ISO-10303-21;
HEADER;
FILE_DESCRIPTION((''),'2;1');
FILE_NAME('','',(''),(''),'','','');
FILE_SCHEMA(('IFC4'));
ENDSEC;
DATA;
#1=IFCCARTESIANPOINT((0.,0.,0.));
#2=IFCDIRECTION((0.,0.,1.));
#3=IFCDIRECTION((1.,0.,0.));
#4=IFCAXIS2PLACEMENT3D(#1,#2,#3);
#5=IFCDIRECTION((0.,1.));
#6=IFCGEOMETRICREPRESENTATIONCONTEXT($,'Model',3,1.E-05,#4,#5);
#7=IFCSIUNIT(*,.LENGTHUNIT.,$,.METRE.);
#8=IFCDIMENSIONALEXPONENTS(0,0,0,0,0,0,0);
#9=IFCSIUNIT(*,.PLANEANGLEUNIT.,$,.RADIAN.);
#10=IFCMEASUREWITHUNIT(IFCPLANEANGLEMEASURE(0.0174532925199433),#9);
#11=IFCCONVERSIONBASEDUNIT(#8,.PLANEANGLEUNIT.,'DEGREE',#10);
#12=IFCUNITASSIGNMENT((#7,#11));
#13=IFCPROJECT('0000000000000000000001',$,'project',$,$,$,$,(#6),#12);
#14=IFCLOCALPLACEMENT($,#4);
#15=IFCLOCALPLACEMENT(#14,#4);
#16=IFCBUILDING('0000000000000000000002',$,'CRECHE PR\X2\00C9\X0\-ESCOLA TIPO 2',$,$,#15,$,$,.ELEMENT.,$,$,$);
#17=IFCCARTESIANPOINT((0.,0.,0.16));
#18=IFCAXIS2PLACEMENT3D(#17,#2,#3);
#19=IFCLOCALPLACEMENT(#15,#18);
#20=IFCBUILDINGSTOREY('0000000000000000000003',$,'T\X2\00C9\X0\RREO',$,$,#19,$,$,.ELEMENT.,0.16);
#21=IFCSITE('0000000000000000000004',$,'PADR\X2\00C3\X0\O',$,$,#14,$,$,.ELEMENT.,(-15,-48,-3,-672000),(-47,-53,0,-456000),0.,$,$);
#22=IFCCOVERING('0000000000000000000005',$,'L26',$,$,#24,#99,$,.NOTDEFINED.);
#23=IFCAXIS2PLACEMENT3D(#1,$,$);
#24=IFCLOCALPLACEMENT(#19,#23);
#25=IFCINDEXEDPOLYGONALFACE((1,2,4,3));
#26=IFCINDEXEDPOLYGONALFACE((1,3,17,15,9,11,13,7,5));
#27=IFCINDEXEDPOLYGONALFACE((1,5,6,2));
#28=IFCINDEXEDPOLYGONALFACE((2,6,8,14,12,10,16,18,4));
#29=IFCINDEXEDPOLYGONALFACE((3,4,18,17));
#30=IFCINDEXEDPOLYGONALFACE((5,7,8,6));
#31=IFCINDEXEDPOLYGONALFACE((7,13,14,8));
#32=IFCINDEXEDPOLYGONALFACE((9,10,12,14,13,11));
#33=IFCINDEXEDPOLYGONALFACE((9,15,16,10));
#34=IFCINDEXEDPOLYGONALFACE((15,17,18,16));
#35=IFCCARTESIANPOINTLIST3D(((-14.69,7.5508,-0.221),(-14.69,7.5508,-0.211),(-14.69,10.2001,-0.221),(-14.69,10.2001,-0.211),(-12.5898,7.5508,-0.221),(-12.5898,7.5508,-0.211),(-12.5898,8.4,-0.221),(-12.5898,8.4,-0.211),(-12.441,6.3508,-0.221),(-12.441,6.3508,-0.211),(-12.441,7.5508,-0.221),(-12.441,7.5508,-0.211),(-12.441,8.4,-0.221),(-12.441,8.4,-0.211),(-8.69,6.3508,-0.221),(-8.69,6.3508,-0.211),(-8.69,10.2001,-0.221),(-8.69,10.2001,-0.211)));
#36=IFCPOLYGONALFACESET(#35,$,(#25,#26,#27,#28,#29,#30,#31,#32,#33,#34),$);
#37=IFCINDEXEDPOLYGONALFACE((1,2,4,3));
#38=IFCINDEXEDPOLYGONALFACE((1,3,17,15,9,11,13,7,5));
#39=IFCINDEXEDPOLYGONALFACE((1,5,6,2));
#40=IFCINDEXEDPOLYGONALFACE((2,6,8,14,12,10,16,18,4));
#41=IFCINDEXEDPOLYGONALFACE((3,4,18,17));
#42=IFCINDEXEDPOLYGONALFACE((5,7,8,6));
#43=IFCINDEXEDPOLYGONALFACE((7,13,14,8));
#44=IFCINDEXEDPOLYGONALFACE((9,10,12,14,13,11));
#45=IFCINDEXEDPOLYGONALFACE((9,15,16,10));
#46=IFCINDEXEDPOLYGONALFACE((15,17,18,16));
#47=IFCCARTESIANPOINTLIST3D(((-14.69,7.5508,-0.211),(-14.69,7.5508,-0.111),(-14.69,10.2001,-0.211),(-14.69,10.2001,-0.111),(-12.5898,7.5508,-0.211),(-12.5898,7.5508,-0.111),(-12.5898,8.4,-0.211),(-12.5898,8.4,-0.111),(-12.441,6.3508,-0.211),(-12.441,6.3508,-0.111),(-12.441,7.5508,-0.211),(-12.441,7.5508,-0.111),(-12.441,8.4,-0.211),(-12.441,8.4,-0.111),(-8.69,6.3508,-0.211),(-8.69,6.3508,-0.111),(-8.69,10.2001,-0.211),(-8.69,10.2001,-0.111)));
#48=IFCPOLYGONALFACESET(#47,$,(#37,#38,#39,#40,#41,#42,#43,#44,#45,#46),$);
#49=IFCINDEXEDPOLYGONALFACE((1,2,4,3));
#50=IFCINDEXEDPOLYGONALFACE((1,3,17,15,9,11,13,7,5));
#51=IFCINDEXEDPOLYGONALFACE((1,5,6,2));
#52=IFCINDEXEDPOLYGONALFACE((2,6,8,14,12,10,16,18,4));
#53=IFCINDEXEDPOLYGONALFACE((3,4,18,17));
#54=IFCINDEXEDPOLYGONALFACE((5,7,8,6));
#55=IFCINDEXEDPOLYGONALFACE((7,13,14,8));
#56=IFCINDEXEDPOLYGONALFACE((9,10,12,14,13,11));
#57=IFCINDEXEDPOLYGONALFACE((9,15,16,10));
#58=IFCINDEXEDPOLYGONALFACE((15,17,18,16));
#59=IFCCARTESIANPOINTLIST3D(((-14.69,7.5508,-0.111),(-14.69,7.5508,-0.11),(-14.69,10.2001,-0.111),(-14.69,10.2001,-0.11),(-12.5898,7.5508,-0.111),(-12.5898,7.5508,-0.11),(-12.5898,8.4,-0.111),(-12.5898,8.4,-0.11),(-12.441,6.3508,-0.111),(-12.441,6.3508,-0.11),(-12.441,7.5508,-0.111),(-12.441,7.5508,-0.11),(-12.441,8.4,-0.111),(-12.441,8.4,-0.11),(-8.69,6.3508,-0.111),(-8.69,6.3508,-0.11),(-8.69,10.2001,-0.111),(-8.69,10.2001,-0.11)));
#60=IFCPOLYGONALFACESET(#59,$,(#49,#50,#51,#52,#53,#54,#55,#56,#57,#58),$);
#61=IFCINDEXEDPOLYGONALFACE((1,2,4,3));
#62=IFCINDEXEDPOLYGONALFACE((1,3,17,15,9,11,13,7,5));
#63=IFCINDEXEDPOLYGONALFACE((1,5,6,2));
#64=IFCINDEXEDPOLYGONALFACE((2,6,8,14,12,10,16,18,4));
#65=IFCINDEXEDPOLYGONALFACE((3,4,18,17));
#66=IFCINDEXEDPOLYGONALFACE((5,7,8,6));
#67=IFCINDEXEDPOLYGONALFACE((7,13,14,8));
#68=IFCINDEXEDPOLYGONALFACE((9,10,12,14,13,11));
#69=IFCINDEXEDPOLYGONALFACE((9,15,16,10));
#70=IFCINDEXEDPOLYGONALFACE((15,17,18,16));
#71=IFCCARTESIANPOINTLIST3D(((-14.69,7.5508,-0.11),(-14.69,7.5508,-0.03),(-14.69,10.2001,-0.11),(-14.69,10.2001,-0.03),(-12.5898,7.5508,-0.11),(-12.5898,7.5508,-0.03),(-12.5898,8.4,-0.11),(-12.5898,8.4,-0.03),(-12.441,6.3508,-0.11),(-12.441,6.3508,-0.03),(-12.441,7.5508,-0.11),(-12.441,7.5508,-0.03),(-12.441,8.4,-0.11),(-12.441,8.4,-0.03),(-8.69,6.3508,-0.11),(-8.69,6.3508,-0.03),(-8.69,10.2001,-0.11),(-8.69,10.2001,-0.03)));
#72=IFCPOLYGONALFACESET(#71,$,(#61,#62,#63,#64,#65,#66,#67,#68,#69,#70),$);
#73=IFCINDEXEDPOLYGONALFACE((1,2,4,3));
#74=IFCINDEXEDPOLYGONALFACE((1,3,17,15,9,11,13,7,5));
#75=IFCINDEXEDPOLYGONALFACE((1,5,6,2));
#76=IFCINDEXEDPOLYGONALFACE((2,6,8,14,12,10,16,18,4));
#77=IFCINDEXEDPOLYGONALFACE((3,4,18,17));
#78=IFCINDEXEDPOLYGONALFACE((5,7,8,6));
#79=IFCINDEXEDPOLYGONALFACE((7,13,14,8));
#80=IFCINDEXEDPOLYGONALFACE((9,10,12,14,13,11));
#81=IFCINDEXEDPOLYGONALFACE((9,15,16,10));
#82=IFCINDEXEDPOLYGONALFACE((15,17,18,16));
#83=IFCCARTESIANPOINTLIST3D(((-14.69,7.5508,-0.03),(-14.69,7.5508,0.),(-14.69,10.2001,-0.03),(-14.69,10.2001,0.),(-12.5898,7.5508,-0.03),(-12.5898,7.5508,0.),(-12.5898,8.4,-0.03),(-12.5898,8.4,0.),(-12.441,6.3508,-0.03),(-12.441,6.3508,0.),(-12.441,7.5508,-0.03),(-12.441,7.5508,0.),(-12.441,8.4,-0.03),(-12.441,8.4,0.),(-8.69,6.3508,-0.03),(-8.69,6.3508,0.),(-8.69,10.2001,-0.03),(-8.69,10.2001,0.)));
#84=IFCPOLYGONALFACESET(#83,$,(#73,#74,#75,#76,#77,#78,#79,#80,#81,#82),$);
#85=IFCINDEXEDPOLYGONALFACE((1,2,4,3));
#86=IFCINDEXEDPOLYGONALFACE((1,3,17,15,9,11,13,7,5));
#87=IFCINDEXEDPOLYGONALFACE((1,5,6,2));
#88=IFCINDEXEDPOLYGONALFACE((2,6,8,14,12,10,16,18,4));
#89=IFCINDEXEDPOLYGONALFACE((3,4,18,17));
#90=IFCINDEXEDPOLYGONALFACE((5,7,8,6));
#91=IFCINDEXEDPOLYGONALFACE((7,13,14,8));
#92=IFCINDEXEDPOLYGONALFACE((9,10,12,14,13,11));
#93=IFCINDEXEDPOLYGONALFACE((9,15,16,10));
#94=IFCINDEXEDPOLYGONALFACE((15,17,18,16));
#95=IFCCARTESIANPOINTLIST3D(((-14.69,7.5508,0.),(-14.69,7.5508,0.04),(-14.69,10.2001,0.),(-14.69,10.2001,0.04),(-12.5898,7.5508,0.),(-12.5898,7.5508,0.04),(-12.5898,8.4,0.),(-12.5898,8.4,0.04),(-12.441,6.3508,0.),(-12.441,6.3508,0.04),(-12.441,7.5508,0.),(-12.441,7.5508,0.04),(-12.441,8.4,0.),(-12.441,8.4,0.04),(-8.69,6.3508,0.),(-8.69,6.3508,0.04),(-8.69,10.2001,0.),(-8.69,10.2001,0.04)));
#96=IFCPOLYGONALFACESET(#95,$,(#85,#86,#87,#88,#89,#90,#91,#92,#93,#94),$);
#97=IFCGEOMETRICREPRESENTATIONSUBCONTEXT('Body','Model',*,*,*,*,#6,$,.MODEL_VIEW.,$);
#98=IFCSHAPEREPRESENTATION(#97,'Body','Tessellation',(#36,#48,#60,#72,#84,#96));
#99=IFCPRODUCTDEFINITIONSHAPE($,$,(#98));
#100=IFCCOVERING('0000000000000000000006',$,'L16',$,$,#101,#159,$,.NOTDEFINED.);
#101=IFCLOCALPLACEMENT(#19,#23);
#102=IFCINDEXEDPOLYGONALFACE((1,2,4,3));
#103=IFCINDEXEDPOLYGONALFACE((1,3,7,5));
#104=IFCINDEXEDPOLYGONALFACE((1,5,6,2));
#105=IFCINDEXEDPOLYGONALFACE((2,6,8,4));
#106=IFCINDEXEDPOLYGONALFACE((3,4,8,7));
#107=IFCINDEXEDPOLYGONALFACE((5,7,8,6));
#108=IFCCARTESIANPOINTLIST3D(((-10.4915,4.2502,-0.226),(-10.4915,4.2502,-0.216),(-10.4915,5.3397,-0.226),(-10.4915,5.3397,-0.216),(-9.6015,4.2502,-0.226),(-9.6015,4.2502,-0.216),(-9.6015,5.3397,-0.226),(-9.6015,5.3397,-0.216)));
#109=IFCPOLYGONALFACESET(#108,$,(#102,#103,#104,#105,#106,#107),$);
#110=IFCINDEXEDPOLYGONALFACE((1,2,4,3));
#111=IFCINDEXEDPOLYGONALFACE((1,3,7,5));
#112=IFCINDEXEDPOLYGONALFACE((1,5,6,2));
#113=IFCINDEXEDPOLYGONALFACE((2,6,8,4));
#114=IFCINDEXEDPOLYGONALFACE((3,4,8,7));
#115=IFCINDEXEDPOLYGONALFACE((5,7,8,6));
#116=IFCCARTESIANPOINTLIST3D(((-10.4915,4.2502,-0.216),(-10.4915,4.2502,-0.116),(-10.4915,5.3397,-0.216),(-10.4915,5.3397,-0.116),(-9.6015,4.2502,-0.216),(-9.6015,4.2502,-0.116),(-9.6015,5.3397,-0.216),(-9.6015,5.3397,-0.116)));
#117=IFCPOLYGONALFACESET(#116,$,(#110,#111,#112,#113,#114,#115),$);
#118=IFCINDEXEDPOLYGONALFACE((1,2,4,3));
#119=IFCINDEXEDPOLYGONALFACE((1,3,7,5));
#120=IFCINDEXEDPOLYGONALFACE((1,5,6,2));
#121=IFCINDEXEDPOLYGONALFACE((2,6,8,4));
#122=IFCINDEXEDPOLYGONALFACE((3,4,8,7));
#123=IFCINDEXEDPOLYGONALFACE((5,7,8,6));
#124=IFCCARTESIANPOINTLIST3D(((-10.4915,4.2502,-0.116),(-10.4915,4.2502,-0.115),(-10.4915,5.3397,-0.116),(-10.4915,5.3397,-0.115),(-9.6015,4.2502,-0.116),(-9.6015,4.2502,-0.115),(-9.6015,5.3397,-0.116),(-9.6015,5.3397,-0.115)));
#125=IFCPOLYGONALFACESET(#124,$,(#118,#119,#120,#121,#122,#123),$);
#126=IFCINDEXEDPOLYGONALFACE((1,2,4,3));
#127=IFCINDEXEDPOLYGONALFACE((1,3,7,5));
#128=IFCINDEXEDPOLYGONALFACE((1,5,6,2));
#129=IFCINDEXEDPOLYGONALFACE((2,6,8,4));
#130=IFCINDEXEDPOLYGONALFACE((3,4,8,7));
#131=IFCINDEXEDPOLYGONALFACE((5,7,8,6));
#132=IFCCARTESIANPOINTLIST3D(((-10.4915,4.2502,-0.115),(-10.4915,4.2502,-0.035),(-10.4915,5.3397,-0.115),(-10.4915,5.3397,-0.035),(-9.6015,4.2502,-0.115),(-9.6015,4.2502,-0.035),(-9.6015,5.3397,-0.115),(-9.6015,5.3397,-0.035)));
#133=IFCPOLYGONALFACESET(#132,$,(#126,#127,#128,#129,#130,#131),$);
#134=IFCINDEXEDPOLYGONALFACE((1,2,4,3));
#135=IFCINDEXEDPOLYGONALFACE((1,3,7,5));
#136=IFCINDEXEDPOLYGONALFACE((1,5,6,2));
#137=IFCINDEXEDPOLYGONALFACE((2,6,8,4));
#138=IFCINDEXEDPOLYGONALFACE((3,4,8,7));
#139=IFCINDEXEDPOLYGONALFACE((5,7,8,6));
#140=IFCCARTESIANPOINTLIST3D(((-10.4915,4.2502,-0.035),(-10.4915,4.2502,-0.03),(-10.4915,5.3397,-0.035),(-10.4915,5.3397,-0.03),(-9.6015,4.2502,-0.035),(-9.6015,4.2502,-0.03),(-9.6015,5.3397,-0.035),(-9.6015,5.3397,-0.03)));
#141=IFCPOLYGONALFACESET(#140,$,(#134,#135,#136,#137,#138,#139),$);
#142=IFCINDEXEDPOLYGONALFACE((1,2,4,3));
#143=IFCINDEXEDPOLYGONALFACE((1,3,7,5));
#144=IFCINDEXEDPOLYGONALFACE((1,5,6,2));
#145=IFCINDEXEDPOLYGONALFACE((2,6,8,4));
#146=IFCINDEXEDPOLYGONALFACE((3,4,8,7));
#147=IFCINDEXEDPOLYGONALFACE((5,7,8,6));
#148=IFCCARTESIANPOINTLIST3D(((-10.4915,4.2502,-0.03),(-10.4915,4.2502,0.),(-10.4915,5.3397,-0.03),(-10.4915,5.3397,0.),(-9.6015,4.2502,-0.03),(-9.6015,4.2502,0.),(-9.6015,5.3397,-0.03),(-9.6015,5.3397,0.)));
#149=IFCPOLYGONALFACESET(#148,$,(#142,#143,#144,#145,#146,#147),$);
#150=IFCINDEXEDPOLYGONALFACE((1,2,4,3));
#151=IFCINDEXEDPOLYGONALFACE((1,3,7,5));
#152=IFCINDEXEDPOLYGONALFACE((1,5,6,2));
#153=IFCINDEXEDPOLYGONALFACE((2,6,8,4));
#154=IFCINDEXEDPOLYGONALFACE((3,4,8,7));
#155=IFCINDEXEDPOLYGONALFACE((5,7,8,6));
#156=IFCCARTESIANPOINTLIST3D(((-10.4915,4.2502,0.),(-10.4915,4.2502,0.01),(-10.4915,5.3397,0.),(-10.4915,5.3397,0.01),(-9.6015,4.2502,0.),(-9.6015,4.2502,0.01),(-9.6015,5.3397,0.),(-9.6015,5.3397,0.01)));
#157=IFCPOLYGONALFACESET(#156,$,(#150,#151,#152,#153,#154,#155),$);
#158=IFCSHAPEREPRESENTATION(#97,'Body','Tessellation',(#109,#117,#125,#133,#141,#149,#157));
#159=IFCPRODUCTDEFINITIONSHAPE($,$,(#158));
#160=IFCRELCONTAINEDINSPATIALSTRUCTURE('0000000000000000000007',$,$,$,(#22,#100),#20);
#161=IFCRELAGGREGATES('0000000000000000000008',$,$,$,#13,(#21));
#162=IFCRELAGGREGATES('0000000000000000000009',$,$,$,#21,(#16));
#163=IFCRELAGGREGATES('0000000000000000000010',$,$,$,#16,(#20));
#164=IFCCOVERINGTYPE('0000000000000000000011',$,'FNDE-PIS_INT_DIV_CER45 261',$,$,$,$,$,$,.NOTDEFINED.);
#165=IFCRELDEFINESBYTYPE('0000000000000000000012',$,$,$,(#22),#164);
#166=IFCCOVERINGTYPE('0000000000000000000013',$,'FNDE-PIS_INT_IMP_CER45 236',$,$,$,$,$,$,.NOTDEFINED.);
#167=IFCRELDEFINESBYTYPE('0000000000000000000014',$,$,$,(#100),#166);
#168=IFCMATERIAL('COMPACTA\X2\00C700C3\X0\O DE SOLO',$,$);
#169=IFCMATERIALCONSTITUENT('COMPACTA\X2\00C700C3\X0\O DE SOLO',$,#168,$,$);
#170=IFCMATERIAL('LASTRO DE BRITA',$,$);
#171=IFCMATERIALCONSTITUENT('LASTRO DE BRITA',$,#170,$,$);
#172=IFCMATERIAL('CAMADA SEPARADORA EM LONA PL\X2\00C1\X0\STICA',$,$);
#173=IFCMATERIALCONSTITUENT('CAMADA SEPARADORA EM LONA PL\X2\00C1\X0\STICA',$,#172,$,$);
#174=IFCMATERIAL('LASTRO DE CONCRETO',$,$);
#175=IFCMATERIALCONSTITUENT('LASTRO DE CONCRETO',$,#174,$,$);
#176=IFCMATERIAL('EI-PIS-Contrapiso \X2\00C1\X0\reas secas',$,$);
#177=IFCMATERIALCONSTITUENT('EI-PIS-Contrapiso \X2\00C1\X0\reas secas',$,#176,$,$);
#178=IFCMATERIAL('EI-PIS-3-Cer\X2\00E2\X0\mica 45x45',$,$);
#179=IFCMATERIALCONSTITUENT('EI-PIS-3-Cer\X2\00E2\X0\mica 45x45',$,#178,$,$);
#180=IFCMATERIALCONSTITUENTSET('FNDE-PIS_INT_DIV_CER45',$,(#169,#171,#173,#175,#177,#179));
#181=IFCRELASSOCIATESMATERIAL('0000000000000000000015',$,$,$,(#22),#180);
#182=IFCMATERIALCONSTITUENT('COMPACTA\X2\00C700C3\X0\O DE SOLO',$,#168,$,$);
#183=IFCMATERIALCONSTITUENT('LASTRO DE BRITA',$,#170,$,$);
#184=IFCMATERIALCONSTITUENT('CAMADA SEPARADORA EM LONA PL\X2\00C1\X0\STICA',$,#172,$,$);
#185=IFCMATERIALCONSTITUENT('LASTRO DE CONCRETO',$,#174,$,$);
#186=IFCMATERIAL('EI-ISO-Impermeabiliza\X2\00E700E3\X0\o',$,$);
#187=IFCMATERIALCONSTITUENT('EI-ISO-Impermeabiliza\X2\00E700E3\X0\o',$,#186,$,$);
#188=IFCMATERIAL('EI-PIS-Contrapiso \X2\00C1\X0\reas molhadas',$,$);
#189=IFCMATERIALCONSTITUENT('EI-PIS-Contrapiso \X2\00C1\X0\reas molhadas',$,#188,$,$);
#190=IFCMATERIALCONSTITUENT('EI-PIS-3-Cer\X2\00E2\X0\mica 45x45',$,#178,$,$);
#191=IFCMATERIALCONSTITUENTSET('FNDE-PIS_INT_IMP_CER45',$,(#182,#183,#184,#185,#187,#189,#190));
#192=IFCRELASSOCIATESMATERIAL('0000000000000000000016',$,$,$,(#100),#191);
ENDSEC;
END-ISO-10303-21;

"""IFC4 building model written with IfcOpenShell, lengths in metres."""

from ifc_helpers import new_model, entity, si_unit, converted_unit, direction, frame, origin_with_axes, place, context, subcontext, project, spatial, line, indexed_curve, outline, extrude, material, constituent, constituent_set, type_object, element, save


model = new_model("IFC4")

# Units and contexts
model_context = context("Model", 3, precision=1e-05, world=origin_with_axes(), true_north=direction((0.0, 1.0)))
body_context = subcontext(model_context, "Body", "Model", "MODEL_VIEW")
ifc_project = project(units=[si_unit("LENGTHUNIT", "METRE"), converted_unit("PLANEANGLEUNIT", "DEGREE", entity("IfcPlaneAngleMeasure", 0.0174532925199433), si_unit("PLANEANGLEUNIT", "RADIAN"), dimensions=[0, 0, 0, 0, 0, 0, 0])], contexts=[model_context])

# Site, building, storey
site_placement = place(None, origin_with_axes())
site = spatial("IfcSite", under=ifc_project, at=site_placement, Name="PADRÃO", CompositionType="ELEMENT", RefLatitude=(-15, -48, -3, -672000), RefLongitude=(-47, -53, 0, -456000), RefElevation=0.0)
building_placement = place(site_placement, origin_with_axes())
building = spatial("IfcBuilding", under=site, at=building_placement, Name="CRECHE PRÉ-ESCOLA TIPO 2", CompositionType="ELEMENT")
storey_placement = place(building_placement, frame((0.0, 0.0, 0.16), z_axis=(0.0, 0.0, 1.0), x_axis=(1.0, 0.0, 0.0)))
storey = spatial("IfcBuildingStorey", under=building, at=storey_placement, Name="TÉRREO", CompositionType="ELEMENT", Elevation=0.16)

# Coverings
ifc_material_1 = material(Name="COMPACTAÇÃO DE SOLO")
ifc_constituent_1 = constituent(ifc_material_1, Name="COMPACTAÇÃO DE SOLO")
ifc_material_2 = material(Name="LASTRO DE BRITA")
ifc_constituent_2 = constituent(ifc_material_2, Name="LASTRO DE BRITA")
ifc_material_3 = material(Name="CAMADA SEPARADORA EM LONA PLÁSTICA")
ifc_constituent_3 = constituent(ifc_material_3, Name="CAMADA SEPARADORA EM LONA PLÁSTICA")
ifc_material_4 = material(Name="LASTRO DE CONCRETO")
ifc_constituent_4 = constituent(ifc_material_4, Name="LASTRO DE CONCRETO")
ifc_material_5 = material(Name="EI-PIS-Contrapiso Áreas secas")
ifc_constituent_5 = constituent(ifc_material_5, Name="EI-PIS-Contrapiso Áreas secas")
ifc_material_6 = material(Name="EI-PIS-3-Cerâmica 45x45")
ifc_constituent_6 = constituent(ifc_material_6, Name="EI-PIS-3-Cerâmica 45x45")
ifc_constituent_set_1 = constituent_set(constituents=[ifc_constituent_1, ifc_constituent_2, ifc_constituent_3, ifc_constituent_4, ifc_constituent_5, ifc_constituent_6], Name="FNDE-PIS_INT_DIV_CER45")
covering_type_1 = type_object("IfcCoveringType", Name="FNDE-PIS_INT_DIV_CER45 261", PredefinedType="NOTDEFINED")
covering_1_placement = place(storey_placement, frame((-8.69, 10.2001, 0.04), z_axis=(0.0, 0.0, 1.0), x_axis=(1.0, 0.0, 0.0)))
element("IfcCovering", 1, at=covering_1_placement, inside=storey, type_object=covering_type_1, material=ifc_constituent_set_1, Name="L26", PredefinedType="NOTDEFINED", context=body_context, shape_type="SweptSolid", body=[
    extrude(outline(indexed_curve([(0.0, 0.0), (-6.0, 0.0), (-6.0, -2.6493), (-3.8998, -2.6493), (-3.8998, -1.8001), (-3.751, -1.8001), (-3.751, -2.6493), (-3.751, -3.8493), (0.0, -3.8493)], segments=[line(1, 2, 3, 4, 5, 6, 7, 8, 9, 1)])), frame((0.0, 0.0, -0.261), z_axis=(0.0, 0.0, 1.0), x_axis=(1.0, 0.0, 0.0)), (0.0, 0.0, 1.0), 0.01),
    extrude(outline(indexed_curve([(0.0, 0.0), (-6.0, 0.0), (-6.0, -2.6493), (-3.8998, -2.6493), (-3.8998, -1.8001), (-3.751, -1.8001), (-3.751, -2.6493), (-3.751, -3.8493), (0.0, -3.8493)], segments=[line(1, 2, 3, 4, 5, 6, 7, 8, 9, 1)])), frame((0.0, 0.0, -0.251), z_axis=(0.0, 0.0, 1.0), x_axis=(1.0, 0.0, 0.0)), (0.0, 0.0, 1.0), 0.1),
    extrude(outline(indexed_curve([(0.0, 0.0), (-6.0, 0.0), (-6.0, -2.6493), (-3.8998, -2.6493), (-3.8998, -1.8001), (-3.751, -1.8001), (-3.751, -2.6493), (-3.751, -3.8493), (0.0, -3.8493)], segments=[line(1, 2, 3, 4, 5, 6, 7, 8, 9, 1)])), frame((0.0, 0.0, -0.151), z_axis=(0.0, 0.0, 1.0), x_axis=(1.0, 0.0, 0.0)), (0.0, 0.0, 1.0), 0.001),
    extrude(outline(indexed_curve([(0.0, 0.0), (-6.0, 0.0), (-6.0, -2.6493), (-3.8998, -2.6493), (-3.8998, -1.8001), (-3.751, -1.8001), (-3.751, -2.6493), (-3.751, -3.8493), (0.0, -3.8493)], segments=[line(1, 2, 3, 4, 5, 6, 7, 8, 9, 1)])), frame((0.0, 0.0, -0.15), z_axis=(0.0, 0.0, 1.0), x_axis=(1.0, 0.0, 0.0)), (0.0, 0.0, 1.0), 0.08),
    extrude(outline(indexed_curve([(0.0, 0.0), (-6.0, 0.0), (-6.0, -2.6493), (-3.8998, -2.6493), (-3.8998, -1.8001), (-3.751, -1.8001), (-3.751, -2.6493), (-3.751, -3.8493), (0.0, -3.8493)], segments=[line(1, 2, 3, 4, 5, 6, 7, 8, 9, 1)])), frame((0.0, 0.0, -0.07), z_axis=(0.0, 0.0, 1.0), x_axis=(1.0, 0.0, 0.0)), (0.0, 0.0, 1.0), 0.03),
    extrude(outline(indexed_curve([(0.0, 0.0), (-6.0, 0.0), (-6.0, -2.6493), (-3.8998, -2.6493), (-3.8998, -1.8001), (-3.751, -1.8001), (-3.751, -2.6493), (-3.751, -3.8493), (0.0, -3.8493)], segments=[line(1, 2, 3, 4, 5, 6, 7, 8, 9, 1)])), frame((0.0, 0.0, -0.04), z_axis=(0.0, 0.0, 1.0), x_axis=(1.0, 0.0, 0.0)), (0.0, 0.0, 1.0), 0.04),
])
ifc_constituent_7 = constituent(ifc_material_1, Name="COMPACTAÇÃO DE SOLO")
ifc_constituent_8 = constituent(ifc_material_2, Name="LASTRO DE BRITA")
ifc_constituent_9 = constituent(ifc_material_3, Name="CAMADA SEPARADORA EM LONA PLÁSTICA")
ifc_constituent_10 = constituent(ifc_material_4, Name="LASTRO DE CONCRETO")
ifc_material_7 = material(Name="EI-ISO-Impermeabilização")
ifc_constituent_11 = constituent(ifc_material_7, Name="EI-ISO-Impermeabilização")
ifc_material_8 = material(Name="EI-PIS-Contrapiso Áreas molhadas")
ifc_constituent_12 = constituent(ifc_material_8, Name="EI-PIS-Contrapiso Áreas molhadas")
ifc_constituent_13 = constituent(ifc_material_6, Name="EI-PIS-3-Cerâmica 45x45")
ifc_constituent_set_2 = constituent_set(constituents=[ifc_constituent_7, ifc_constituent_8, ifc_constituent_9, ifc_constituent_10, ifc_constituent_11, ifc_constituent_12, ifc_constituent_13], Name="FNDE-PIS_INT_IMP_CER45")
covering_type_2 = type_object("IfcCoveringType", Name="FNDE-PIS_INT_IMP_CER45 236", PredefinedType="NOTDEFINED")
covering_2_placement = place(storey_placement, frame((-9.6015, 5.3397, 0.01), z_axis=(0.0, 0.0, 1.0), x_axis=(1.0, 0.0, 0.0)))
element("IfcCovering", 2, at=covering_2_placement, inside=storey, type_object=covering_type_2, material=ifc_constituent_set_2, Name="L16", PredefinedType="NOTDEFINED", context=body_context, shape_type="SweptSolid", body=[
    extrude(outline(indexed_curve([(0.0, 0.0), (-0.89, 0.0), (-0.89, -1.0895), (0.0, -1.0895)], segments=[line(1, 2, 3, 4, 1)])), frame((0.0, 0.0, -0.236), z_axis=(0.0, 0.0, 1.0), x_axis=(1.0, 0.0, 0.0)), (0.0, 0.0, 1.0), 0.01),
    extrude(outline(indexed_curve([(0.0, 0.0), (-0.89, 0.0), (-0.89, -1.0895), (0.0, -1.0895)], segments=[line(1, 2, 3, 4, 1)])), frame((0.0, 0.0, -0.226), z_axis=(0.0, 0.0, 1.0), x_axis=(1.0, 0.0, 0.0)), (0.0, 0.0, 1.0), 0.1),
    extrude(outline(indexed_curve([(0.0, 0.0), (-0.89, 0.0), (-0.89, -1.0895), (0.0, -1.0895)], segments=[line(1, 2, 3, 4, 1)])), frame((0.0, 0.0, -0.126), z_axis=(0.0, 0.0, 1.0), x_axis=(1.0, 0.0, 0.0)), (0.0, 0.0, 1.0), 0.001),
    extrude(outline(indexed_curve([(0.0, 0.0), (-0.89, 0.0), (-0.89, -1.0895), (0.0, -1.0895)], segments=[line(1, 2, 3, 4, 1)])), frame((0.0, 0.0, -0.125), z_axis=(0.0, 0.0, 1.0), x_axis=(1.0, 0.0, 0.0)), (0.0, 0.0, 1.0), 0.08),
    extrude(outline(indexed_curve([(0.0, 0.0), (-0.89, 0.0), (-0.89, -1.0895), (0.0, -1.0895)], segments=[line(1, 2, 3, 4, 1)])), frame((0.0, 0.0, -0.045), z_axis=(0.0, 0.0, 1.0), x_axis=(1.0, 0.0, 0.0)), (0.0, 0.0, 1.0), 0.005),
    extrude(outline(indexed_curve([(0.0, 0.0), (-0.89, 0.0), (-0.89, -1.0895), (0.0, -1.0895)], segments=[line(1, 2, 3, 4, 1)])), frame((0.0, 0.0, -0.04), z_axis=(0.0, 0.0, 1.0), x_axis=(1.0, 0.0, 0.0)), (0.0, 0.0, 1.0), 0.03),
    extrude(outline(indexed_curve([(0.0, 0.0), (-0.89, 0.0), (-0.89, -1.0895), (0.0, -1.0895)], segments=[line(1, 2, 3, 4, 1)])), frame((0.0, 0.0, -0.01), z_axis=(0.0, 0.0, 1.0), x_axis=(1.0, 0.0, 0.0)), (0.0, 0.0, 1.0), 0.01),
])

save(model, "model.ifc")
